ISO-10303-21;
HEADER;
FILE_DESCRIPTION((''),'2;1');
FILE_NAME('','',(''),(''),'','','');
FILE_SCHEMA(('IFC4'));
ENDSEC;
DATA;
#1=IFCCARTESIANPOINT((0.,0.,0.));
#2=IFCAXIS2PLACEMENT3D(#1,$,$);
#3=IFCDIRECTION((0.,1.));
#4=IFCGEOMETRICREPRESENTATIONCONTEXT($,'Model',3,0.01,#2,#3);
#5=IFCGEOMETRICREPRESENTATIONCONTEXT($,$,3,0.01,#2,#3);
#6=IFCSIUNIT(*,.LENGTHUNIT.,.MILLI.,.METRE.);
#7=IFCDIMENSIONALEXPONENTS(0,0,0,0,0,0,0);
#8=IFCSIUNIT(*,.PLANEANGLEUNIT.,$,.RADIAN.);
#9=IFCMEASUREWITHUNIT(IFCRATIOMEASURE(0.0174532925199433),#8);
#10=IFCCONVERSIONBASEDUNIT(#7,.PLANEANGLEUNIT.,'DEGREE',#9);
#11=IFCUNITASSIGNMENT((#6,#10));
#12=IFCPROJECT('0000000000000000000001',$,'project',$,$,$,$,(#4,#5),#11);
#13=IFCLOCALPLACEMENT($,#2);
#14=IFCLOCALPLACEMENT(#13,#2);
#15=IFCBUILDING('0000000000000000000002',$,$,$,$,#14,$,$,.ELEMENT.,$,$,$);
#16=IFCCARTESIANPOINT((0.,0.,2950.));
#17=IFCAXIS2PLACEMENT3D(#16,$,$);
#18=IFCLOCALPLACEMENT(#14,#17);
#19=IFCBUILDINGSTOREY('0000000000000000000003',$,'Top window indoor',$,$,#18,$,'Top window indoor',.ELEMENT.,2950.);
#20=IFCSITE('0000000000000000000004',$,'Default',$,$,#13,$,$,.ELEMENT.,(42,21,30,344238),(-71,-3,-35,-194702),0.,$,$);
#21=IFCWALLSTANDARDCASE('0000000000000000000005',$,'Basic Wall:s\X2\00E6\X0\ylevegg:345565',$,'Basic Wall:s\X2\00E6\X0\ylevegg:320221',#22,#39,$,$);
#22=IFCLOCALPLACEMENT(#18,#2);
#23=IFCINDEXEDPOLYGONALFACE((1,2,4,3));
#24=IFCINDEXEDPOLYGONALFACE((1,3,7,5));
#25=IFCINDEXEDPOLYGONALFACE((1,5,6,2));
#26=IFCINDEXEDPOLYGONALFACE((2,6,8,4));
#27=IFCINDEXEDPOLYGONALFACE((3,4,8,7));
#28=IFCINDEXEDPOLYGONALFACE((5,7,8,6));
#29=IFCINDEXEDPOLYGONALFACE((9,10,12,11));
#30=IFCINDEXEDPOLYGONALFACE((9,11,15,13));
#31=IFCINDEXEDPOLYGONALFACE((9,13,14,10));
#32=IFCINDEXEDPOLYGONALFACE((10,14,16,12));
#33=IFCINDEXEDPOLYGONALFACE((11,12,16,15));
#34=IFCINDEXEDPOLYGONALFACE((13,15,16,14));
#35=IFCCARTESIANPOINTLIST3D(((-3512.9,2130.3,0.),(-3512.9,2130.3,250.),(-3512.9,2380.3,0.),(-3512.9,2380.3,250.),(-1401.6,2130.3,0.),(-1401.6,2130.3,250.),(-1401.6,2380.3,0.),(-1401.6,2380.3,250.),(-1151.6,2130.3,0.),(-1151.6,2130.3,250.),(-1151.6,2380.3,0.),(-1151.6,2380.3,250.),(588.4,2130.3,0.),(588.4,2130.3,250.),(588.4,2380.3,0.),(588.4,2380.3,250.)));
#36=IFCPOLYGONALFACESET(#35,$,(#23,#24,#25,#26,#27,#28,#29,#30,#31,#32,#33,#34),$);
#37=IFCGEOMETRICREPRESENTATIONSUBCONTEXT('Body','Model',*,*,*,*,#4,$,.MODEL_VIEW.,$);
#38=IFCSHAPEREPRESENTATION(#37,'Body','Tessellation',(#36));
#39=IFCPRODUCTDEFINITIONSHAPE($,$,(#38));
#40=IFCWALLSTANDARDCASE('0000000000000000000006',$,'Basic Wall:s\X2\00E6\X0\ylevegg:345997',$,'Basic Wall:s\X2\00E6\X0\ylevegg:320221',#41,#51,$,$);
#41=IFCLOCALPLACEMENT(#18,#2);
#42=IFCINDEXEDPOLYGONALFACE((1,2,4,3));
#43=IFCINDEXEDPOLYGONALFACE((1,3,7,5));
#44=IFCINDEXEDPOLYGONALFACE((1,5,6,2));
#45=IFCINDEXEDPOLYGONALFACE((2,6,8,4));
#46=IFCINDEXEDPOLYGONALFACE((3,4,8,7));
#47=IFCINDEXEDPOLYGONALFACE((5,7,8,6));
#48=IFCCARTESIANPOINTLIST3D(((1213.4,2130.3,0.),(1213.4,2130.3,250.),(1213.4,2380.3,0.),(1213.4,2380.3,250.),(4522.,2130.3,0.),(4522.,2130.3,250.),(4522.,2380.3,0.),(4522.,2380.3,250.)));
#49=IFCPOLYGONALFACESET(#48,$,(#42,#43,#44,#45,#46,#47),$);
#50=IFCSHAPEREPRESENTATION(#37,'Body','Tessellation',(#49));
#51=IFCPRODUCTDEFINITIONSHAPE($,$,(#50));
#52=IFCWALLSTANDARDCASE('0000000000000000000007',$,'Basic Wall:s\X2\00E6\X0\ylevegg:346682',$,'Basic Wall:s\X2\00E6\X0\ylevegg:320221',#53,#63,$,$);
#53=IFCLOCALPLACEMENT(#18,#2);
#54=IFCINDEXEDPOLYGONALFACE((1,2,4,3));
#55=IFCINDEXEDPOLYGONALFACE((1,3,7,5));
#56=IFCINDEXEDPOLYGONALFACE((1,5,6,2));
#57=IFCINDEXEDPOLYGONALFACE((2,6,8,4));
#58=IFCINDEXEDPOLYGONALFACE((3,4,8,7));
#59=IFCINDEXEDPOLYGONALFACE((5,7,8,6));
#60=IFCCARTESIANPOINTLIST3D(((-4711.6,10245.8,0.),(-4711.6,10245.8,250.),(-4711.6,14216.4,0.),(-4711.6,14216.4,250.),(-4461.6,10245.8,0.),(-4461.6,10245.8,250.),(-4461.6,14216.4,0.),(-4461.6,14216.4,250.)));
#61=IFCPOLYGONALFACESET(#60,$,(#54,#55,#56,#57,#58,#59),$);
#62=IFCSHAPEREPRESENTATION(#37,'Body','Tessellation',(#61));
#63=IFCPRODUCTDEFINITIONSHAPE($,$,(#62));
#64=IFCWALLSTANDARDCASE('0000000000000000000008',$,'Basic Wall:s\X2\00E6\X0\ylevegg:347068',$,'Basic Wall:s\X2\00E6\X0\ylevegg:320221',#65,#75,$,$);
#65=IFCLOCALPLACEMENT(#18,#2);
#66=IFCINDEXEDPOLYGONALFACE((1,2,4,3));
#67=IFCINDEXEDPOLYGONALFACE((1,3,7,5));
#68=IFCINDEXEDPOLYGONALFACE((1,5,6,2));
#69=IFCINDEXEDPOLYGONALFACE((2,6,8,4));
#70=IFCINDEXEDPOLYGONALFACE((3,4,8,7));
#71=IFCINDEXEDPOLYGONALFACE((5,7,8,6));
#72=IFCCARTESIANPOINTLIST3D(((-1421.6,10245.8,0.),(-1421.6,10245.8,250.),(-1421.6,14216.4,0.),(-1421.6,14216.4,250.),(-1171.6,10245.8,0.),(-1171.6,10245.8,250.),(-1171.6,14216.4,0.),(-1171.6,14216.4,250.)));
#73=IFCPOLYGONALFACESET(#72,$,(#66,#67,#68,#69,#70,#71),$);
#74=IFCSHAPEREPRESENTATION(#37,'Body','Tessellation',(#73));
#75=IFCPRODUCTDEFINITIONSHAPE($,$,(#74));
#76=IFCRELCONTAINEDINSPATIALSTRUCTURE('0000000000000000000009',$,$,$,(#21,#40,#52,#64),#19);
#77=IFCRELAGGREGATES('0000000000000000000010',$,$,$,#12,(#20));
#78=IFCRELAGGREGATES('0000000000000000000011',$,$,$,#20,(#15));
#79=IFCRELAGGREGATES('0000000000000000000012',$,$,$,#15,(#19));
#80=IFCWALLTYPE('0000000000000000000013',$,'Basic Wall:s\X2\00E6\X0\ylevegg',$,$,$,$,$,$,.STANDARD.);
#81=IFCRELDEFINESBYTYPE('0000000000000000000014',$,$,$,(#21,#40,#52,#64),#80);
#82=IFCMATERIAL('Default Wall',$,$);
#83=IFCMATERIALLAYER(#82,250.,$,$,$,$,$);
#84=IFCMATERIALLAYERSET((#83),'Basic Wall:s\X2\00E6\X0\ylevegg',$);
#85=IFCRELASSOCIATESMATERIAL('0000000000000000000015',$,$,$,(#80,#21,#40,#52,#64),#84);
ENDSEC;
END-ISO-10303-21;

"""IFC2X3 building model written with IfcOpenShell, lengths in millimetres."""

from ifc_helpers import new_model, entity, si_unit, converted_unit, direction, frame, frame_2d, origin, origin_2d_with_axis, place, context, subcontext, project, spatial, rectangle, extrude, material, layer, layer_set, layer_usage, type_object, element, save


model = new_model("IFC2X3")

# Units and contexts
model_context = context("Model", 3, precision=0.01, world=origin(), true_north=direction((0.0, 1.0)))
context_of_model = context(None, 3, precision=0.01, world=origin(), true_north=direction((0.0, 1.0)))
body_context = subcontext(model_context, "Body", "Model", "MODEL_VIEW")
ifc_project = project(units=[si_unit("LENGTHUNIT", "METRE", prefix="MILLI"), converted_unit("PLANEANGLEUNIT", "DEGREE", entity("IfcRatioMeasure", 0.0174532925199433), si_unit("PLANEANGLEUNIT", "RADIAN"), dimensions=[0, 0, 0, 0, 0, 0, 0])], contexts=[model_context, context_of_model])

# Site, building, storey
site_placement = place(None, origin())
site = spatial("IfcSite", under=ifc_project, at=site_placement, Name="Default", CompositionType="ELEMENT", RefLatitude=(42, 21, 30, 344238), RefLongitude=(-71, -3, -35, -194702), RefElevation=0.0)
building_placement = place(site_placement, origin())
building = spatial("IfcBuilding", under=site, at=building_placement, CompositionType="ELEMENT")
storey_placement = place(building_placement, frame((0.0, 0.0, 2950.0)))
storey = spatial("IfcBuildingStorey", under=building, at=storey_placement, Name="Top window indoor", LongName="Top window indoor", CompositionType="ELEMENT", Elevation=2950.0)

# Wall, opening
ifc_material = material(Name="Default Wall")
ifc_layer = layer(ifc_material, 250.0)
ifc_layer_set = layer_set([ifc_layer], Name="Basic Wall:sæylevegg")
ifc_layer_usage_1 = layer_usage(ifc_layer_set, "AXIS2", "NEGATIVE", 125.0)
wall_type = type_object("IfcWallType", Name="Basic Wall:sæylevegg", PredefinedType="STANDARD", material=ifc_layer_set)
wall_1_placement = place(storey_placement, frame((-3512.9, 2255.3, 0.0)))
wall_1 = element("IfcWallStandardCase", 1, at=wall_1_placement, inside=storey, type_object=wall_type, material=ifc_layer_usage_1, Name="Basic Wall:sæylevegg:345565", ObjectType="Basic Wall:sæylevegg:320221", context=body_context, shape_type="SweptSolid", body=[
    extrude(rectangle(XDim=4101.3, YDim=250.0, at=frame_2d((2050.7, 0.0), x_axis=(-1.0, 0.0))), origin(), (0.0, 0.0, 1.0), 250.0),
])
opening_placement = place(storey_placement, frame((-3512.9, 2255.3, 0.0)))
element("IfcOpeningElement", 2, at=opening_placement, cuts=wall_1, ObjectType="Opening", context=body_context, shape_type="SweptSolid", body=[
    extrude(rectangle(XDim=250.0, YDim=250.0, at=origin_2d_with_axis()), frame((2111.3, 0.0, 125.0), z_axis=(1.0, 0.0, 0.0), x_axis=(0.0, 0.0, -1.0)), (0.0, 0.0, 1.0), 250.0),
])

# Walls
ifc_layer_usage_2 = layer_usage(ifc_layer_set, "AXIS2", "NEGATIVE", 125.0)
wall_2_placement = place(storey_placement, frame((1213.4, 2255.3, 0.0)))
element("IfcWallStandardCase", 3, at=wall_2_placement, inside=storey, type_object=wall_type, material=ifc_layer_usage_2, Name="Basic Wall:sæylevegg:345997", ObjectType="Basic Wall:sæylevegg:320221", context=body_context, shape_type="SweptSolid", body=[
    extrude(rectangle(XDim=3308.6, YDim=250.0, at=frame_2d((1654.3, 0.0), x_axis=(-1.0, 0.0))), origin(), (0.0, 0.0, 1.0), 250.0),
])
ifc_layer_usage_3 = layer_usage(ifc_layer_set, "AXIS2", "NEGATIVE", 125.0)
wall_3_placement = place(storey_placement, frame((-4586.6, 10245.8, 0.0), z_axis=(0.0, 0.0, 1.0), x_axis=(0.0, 1.0, 0.0)))
element("IfcWallStandardCase", 4, at=wall_3_placement, inside=storey, type_object=wall_type, material=ifc_layer_usage_3, Name="Basic Wall:sæylevegg:346682", ObjectType="Basic Wall:sæylevegg:320221", context=body_context, shape_type="SweptSolid", body=[
    extrude(rectangle(XDim=3970.6, YDim=250.0, at=frame_2d((1985.3, 0.0), x_axis=(-1.0, 0.0))), origin(), (0.0, 0.0, 1.0), 250.0),
])
ifc_layer_usage_4 = layer_usage(ifc_layer_set, "AXIS2", "NEGATIVE", 125.0)
wall_4_placement = place(storey_placement, frame((-1296.6, 10245.8, 0.0), z_axis=(0.0, 0.0, 1.0), x_axis=(0.0, 1.0, 0.0)))
element("IfcWallStandardCase", 5, at=wall_4_placement, inside=storey, type_object=wall_type, material=ifc_layer_usage_4, Name="Basic Wall:sæylevegg:347068", ObjectType="Basic Wall:sæylevegg:320221", context=body_context, shape_type="SweptSolid", body=[
    extrude(rectangle(XDim=3970.6, YDim=250.0, at=frame_2d((1985.3, 0.0), x_axis=(-1.0, 0.0))), origin(), (0.0, 0.0, 1.0), 250.0),
])

save(model, "model.ifc")
